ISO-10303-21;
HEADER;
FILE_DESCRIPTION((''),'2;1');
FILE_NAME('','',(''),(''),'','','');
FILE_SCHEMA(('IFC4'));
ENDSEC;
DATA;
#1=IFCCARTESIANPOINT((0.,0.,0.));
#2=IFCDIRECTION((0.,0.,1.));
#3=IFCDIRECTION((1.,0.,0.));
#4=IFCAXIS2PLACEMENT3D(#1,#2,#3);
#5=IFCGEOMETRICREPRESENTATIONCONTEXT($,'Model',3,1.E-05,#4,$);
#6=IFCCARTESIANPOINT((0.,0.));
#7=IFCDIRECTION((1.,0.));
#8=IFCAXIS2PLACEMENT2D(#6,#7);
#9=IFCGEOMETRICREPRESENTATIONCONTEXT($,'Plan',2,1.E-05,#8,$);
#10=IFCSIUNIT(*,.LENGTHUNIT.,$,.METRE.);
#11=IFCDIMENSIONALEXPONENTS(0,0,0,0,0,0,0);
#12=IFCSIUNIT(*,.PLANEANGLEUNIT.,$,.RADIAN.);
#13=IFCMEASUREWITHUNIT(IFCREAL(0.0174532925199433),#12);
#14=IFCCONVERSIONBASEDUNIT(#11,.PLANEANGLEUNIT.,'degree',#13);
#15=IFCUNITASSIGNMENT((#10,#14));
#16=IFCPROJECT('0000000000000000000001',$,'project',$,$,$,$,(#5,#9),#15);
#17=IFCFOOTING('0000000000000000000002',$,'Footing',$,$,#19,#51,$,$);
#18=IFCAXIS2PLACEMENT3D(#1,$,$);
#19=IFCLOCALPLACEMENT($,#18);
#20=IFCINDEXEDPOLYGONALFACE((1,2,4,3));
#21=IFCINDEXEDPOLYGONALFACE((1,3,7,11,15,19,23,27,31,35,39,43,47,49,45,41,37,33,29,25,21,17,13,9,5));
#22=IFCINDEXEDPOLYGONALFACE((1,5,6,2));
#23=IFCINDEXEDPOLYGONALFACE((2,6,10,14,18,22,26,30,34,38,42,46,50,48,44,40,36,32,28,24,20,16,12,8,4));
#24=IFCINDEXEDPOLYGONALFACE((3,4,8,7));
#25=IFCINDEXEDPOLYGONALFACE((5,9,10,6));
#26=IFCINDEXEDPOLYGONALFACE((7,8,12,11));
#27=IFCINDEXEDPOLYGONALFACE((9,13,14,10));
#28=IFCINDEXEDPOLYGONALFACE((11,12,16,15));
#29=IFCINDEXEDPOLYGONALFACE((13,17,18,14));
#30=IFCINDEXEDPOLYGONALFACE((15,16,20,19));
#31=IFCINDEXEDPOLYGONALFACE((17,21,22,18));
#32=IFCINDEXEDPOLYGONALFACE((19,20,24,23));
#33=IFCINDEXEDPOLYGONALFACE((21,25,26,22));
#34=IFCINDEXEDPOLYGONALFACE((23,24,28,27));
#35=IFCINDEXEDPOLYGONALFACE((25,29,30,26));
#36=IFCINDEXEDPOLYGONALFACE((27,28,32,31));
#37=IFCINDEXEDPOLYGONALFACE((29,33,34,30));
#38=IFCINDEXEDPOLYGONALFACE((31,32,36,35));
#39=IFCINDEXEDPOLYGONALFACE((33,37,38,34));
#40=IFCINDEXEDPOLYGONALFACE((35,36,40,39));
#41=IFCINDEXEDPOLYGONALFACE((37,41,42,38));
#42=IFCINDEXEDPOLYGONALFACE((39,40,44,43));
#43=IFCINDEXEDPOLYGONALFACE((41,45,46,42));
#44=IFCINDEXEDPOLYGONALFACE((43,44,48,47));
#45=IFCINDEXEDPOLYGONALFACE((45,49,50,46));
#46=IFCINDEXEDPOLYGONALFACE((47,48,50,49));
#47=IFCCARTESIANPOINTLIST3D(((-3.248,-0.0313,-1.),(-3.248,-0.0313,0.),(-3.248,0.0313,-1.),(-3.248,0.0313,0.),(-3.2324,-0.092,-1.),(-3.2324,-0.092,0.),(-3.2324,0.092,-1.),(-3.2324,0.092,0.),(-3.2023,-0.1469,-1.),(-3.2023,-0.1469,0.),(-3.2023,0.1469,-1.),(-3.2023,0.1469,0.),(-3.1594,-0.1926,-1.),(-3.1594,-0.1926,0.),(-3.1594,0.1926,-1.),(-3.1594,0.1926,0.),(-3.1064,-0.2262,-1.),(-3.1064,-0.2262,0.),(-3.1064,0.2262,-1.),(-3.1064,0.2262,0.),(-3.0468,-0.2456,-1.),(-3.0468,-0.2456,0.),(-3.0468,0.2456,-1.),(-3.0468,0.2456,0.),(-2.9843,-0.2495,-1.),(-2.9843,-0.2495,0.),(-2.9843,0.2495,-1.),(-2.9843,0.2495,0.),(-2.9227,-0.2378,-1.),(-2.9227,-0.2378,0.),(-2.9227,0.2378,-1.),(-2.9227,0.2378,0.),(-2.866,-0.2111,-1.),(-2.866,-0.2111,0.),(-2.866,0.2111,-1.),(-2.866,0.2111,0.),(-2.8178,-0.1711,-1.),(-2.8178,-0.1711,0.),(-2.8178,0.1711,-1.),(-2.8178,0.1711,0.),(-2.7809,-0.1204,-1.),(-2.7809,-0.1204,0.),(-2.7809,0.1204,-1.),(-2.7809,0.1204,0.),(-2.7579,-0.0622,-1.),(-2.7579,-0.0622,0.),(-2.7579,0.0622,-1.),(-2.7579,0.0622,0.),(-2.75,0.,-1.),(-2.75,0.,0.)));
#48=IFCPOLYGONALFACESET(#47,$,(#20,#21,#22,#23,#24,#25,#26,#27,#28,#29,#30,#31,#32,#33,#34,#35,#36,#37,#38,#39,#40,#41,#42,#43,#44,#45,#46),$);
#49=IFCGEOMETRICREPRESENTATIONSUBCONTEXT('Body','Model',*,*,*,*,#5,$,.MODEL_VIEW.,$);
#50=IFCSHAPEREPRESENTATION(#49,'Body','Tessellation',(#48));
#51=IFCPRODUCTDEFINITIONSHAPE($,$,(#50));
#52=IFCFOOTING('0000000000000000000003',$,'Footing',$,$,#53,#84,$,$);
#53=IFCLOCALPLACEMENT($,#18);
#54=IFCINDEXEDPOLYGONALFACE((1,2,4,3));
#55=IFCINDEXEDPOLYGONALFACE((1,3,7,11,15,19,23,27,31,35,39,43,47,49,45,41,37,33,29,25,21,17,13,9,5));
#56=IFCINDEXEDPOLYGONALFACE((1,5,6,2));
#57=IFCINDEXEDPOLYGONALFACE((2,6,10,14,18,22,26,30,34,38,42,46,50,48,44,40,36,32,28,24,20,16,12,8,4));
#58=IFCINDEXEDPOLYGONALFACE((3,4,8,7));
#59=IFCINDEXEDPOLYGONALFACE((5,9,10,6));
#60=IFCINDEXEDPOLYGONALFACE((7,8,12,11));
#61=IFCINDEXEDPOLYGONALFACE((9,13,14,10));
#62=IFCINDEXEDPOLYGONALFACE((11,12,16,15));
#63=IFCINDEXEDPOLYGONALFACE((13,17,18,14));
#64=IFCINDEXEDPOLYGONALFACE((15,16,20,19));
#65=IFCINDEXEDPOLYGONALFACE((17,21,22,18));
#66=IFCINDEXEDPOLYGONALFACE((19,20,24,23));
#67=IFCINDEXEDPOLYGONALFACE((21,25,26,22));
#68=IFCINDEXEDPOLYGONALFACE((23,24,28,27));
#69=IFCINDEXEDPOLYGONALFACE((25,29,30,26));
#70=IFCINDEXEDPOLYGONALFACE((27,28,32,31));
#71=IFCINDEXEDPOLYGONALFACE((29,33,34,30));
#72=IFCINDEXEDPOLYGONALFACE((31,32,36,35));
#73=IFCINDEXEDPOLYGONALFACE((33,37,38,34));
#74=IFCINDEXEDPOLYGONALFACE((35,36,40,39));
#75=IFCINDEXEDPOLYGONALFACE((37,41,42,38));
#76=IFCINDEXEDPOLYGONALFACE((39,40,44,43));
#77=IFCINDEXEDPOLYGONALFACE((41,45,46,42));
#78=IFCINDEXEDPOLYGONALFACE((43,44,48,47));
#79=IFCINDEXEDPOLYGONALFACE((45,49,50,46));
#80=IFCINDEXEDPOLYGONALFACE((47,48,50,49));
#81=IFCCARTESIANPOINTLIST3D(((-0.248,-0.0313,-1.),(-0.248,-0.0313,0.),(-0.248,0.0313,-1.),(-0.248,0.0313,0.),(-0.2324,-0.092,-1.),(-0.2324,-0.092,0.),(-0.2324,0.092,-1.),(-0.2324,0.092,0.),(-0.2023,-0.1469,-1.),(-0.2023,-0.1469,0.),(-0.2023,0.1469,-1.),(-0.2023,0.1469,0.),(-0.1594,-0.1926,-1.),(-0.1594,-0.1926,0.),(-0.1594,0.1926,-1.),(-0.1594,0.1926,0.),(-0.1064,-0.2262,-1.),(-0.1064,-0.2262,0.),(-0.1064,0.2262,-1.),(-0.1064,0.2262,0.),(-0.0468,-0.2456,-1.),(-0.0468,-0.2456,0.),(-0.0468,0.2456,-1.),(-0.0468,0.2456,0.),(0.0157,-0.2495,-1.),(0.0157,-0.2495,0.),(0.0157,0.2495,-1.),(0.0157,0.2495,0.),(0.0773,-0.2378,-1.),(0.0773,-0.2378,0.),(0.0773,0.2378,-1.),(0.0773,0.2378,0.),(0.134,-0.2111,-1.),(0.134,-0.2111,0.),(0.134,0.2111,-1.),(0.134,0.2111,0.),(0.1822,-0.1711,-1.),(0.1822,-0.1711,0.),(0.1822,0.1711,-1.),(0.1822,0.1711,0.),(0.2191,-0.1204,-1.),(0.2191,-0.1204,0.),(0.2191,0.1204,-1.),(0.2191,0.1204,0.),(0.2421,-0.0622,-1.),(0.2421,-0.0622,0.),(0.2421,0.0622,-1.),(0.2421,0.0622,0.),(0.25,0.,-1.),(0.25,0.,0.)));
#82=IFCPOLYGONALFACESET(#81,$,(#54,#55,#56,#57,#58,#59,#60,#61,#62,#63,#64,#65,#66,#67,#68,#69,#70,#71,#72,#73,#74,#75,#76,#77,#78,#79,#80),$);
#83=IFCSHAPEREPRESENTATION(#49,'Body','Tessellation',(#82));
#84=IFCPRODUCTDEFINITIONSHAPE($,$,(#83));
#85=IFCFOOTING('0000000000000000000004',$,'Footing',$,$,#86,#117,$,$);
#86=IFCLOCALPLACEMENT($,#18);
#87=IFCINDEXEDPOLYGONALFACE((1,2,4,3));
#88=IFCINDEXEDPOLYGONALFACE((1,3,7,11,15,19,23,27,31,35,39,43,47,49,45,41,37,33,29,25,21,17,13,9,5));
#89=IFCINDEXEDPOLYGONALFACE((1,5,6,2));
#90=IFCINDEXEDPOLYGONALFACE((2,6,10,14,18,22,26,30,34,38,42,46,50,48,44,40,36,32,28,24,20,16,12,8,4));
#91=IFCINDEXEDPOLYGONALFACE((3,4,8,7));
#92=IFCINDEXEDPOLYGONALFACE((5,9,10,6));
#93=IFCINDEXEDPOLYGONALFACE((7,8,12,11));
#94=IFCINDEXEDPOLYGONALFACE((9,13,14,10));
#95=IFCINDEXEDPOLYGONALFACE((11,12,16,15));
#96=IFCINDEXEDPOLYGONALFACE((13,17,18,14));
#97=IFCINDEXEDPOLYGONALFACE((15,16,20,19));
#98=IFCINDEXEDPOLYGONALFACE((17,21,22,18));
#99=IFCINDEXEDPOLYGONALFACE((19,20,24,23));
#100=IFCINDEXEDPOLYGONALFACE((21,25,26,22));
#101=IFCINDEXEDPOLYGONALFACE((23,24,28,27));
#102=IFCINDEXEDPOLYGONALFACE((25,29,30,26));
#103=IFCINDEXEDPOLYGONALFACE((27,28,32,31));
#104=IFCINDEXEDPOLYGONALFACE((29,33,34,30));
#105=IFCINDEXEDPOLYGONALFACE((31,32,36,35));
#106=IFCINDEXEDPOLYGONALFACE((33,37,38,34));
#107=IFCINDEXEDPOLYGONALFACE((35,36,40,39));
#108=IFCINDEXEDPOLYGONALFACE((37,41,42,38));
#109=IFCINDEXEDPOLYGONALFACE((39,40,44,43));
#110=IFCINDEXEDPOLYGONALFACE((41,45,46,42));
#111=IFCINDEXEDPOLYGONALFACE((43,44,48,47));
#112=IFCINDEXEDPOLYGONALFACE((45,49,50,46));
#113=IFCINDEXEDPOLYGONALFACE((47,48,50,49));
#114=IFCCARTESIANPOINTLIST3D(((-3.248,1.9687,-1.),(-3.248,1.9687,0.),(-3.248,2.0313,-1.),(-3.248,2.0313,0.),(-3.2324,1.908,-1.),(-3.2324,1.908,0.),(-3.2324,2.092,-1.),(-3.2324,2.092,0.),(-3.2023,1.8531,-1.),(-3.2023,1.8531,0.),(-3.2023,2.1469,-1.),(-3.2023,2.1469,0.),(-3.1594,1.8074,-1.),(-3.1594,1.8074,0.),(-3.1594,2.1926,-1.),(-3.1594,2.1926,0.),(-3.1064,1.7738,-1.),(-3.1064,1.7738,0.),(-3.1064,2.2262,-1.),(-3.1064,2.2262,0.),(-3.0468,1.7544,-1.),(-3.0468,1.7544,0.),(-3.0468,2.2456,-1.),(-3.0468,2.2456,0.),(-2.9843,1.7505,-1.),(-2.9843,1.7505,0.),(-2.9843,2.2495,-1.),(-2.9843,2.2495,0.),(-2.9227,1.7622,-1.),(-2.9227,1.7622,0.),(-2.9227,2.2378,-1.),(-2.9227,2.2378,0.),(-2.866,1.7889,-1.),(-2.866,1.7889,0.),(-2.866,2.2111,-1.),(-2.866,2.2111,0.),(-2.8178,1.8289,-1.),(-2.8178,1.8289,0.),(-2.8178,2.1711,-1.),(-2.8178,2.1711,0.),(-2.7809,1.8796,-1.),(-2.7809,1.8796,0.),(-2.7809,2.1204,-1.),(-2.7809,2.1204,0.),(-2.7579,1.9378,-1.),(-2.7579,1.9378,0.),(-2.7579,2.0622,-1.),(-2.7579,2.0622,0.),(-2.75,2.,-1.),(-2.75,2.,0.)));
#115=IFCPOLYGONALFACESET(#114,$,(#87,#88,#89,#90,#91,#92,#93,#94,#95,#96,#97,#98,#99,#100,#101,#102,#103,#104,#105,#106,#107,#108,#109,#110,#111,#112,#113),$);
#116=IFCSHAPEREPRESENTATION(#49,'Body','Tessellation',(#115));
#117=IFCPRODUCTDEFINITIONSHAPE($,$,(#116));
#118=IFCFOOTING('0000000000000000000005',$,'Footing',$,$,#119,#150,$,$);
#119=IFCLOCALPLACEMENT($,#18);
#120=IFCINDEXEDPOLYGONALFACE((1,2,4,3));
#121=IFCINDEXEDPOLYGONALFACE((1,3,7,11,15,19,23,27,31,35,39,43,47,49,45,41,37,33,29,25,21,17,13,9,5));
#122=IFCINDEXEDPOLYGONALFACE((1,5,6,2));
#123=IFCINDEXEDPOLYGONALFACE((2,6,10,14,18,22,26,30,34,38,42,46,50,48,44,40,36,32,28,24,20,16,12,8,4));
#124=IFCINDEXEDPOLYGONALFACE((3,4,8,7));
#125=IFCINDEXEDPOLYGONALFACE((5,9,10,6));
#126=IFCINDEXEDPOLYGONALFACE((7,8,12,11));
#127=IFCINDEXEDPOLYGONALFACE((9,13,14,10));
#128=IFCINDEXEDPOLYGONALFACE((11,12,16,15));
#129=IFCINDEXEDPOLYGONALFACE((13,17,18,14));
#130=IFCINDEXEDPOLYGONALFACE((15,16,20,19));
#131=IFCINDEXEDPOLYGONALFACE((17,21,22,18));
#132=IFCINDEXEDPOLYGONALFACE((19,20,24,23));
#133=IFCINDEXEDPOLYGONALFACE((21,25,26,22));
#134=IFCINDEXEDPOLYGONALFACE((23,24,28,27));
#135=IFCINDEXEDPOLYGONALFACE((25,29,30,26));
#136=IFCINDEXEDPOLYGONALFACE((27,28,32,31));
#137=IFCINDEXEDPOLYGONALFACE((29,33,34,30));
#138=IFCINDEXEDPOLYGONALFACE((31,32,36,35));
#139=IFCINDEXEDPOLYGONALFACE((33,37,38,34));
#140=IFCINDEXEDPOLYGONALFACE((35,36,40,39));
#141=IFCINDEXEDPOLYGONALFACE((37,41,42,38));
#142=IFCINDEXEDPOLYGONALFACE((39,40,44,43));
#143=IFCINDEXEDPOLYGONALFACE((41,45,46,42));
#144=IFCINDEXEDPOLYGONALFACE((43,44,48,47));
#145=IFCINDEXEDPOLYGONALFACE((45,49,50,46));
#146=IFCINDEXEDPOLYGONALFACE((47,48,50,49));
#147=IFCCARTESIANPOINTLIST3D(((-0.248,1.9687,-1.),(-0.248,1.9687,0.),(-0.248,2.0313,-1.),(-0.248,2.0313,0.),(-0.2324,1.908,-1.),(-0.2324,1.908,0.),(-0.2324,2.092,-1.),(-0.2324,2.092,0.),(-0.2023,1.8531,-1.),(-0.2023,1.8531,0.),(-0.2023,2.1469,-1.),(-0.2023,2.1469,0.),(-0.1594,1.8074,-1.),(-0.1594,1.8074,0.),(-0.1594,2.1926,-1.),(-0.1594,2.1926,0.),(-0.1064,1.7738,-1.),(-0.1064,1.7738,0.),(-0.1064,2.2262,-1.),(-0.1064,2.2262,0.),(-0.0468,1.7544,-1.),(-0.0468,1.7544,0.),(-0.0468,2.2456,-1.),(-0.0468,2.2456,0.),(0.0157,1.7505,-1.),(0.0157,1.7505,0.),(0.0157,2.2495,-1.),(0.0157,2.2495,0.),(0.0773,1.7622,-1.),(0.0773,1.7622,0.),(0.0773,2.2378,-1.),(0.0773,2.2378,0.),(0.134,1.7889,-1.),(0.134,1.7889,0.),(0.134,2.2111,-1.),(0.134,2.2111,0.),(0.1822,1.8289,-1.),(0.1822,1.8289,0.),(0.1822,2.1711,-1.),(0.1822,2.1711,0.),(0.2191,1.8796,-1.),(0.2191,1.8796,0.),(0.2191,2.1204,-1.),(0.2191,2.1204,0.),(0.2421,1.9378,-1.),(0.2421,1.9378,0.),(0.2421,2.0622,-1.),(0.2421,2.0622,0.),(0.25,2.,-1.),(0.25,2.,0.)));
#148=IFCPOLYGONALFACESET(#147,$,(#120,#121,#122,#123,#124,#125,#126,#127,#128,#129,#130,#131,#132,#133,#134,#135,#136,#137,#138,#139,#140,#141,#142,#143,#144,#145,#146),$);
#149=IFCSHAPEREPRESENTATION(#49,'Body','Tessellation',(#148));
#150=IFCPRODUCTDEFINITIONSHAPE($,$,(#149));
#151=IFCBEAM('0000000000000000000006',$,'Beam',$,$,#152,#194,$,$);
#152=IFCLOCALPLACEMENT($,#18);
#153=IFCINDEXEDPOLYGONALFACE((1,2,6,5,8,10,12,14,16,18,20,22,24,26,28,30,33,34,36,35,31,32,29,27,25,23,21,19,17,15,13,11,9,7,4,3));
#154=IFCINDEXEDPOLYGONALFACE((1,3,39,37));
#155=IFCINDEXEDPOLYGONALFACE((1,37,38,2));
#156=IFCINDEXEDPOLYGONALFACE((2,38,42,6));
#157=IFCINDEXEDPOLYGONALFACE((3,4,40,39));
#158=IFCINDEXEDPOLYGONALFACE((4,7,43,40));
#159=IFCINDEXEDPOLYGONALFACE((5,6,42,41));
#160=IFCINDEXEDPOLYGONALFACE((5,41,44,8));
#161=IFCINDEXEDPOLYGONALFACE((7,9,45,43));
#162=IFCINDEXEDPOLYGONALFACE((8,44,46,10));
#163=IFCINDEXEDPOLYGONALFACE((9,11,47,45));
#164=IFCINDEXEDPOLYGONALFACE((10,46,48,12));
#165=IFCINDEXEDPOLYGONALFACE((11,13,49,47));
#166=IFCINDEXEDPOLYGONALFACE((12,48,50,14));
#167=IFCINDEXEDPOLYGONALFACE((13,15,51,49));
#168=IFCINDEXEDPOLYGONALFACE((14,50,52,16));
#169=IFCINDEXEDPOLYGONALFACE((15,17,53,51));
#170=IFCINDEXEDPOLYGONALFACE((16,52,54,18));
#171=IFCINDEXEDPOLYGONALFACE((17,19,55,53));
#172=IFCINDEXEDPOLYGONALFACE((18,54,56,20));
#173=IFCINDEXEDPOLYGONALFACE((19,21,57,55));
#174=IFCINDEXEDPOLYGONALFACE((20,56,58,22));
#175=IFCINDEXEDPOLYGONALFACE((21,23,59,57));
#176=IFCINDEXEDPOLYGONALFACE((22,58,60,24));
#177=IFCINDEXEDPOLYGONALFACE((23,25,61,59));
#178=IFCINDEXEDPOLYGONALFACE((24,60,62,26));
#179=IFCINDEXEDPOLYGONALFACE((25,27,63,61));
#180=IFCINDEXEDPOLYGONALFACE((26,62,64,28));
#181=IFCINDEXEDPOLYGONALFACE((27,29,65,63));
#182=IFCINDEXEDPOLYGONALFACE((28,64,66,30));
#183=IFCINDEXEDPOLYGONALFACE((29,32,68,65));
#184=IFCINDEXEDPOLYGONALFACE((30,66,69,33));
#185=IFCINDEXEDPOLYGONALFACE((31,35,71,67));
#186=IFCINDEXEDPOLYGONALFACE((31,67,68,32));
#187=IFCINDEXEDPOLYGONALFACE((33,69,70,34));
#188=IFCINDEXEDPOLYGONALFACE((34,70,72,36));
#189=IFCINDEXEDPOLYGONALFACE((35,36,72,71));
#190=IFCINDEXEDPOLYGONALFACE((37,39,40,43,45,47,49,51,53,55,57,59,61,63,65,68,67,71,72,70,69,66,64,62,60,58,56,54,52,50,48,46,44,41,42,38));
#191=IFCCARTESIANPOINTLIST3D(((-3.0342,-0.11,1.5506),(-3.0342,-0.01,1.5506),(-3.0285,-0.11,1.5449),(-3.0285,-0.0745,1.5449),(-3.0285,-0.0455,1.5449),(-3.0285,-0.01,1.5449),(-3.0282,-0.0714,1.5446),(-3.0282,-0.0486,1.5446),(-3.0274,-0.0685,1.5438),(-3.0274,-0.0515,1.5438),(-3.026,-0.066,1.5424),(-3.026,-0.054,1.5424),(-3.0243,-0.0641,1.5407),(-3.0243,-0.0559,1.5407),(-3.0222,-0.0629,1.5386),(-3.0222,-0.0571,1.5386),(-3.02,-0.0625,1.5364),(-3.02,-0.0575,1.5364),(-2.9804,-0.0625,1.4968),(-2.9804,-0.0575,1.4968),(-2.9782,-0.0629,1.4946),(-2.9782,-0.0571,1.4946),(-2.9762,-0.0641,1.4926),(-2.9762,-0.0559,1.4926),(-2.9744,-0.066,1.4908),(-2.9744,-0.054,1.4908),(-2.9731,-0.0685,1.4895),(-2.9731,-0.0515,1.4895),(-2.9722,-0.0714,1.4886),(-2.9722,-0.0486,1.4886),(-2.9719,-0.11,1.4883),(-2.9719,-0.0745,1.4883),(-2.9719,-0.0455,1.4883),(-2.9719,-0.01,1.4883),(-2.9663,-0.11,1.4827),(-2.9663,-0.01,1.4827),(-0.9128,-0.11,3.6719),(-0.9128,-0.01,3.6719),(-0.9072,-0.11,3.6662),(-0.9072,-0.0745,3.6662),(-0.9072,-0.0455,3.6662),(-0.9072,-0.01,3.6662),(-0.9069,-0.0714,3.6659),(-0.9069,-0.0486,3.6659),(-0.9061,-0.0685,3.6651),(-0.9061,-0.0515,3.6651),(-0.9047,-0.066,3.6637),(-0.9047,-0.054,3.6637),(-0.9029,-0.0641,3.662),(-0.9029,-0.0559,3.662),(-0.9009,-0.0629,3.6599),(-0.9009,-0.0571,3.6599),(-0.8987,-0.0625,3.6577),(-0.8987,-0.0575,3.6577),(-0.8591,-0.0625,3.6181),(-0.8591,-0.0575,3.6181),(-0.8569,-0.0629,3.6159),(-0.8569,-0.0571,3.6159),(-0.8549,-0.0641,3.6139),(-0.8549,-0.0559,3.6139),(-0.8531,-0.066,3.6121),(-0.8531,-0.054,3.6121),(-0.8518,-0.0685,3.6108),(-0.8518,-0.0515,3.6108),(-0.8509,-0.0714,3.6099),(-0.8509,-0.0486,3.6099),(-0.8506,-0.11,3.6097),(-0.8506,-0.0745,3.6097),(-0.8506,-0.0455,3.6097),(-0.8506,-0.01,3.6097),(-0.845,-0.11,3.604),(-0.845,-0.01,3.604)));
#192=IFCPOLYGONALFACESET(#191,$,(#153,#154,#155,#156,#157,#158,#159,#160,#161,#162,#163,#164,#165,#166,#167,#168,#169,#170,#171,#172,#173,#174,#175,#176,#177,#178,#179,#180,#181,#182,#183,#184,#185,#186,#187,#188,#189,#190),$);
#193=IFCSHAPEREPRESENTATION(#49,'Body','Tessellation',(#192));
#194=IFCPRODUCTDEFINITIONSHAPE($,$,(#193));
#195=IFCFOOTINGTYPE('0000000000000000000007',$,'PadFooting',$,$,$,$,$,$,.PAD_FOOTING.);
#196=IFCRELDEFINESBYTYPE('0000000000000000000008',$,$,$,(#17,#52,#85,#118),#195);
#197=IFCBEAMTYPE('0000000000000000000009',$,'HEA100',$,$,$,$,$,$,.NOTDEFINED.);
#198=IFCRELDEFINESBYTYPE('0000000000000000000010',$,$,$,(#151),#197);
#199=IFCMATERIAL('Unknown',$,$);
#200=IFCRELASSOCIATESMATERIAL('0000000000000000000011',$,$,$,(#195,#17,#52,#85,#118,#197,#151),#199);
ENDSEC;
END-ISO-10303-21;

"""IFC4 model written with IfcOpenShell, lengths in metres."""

from ifc_helpers import new_model, entity, si_unit, converted_unit, frame, origin_with_axes, origin_2d_with_axis, place, context, subcontext, project, circle, i_section, extrude, material, material_profile, profile_set, profile_usage, type_object, element, save


model = new_model("IFC4")

# Units and contexts
model_context = context("Model", 3, precision=1e-05, world=origin_with_axes())
plan_context = context("Plan", 2, precision=1e-05, world=origin_2d_with_axis())
body_context = subcontext(model_context, "Body", "Model", "MODEL_VIEW")
ifc_project = project(units=[si_unit("LENGTHUNIT", "METRE"), converted_unit("PLANEANGLEUNIT", "degree", entity("IfcReal", 0.0174532925199433), si_unit("PLANEANGLEUNIT", "RADIAN"), dimensions=[0, 0, 0, 0, 0, 0, 0])], contexts=[model_context, plan_context])

# Footings
ifc_material = material(Name="Unknown")
ifc_material_profile_1 = material_profile(ifc_material, circle(Radius=0.25))
ifc_profile_set_1 = profile_set([ifc_material_profile_1], Name="Round pad")
ifc_profile_usage_1 = profile_usage(ifc_profile_set_1, cardinal=5)
footing_type = type_object("IfcFootingType", Name="PadFooting", PredefinedType="PAD_FOOTING", material=ifc_profile_set_1)
footing_1_placement = place(None, frame((-3.0, 0.0, -1.0), z_axis=(0.0, 0.0, 1.0), x_axis=(1.0, 0.0, 0.0)))
element("IfcFooting", 1, at=footing_1_placement, type_object=footing_type, material=ifc_profile_usage_1, Name="Footing", context=body_context, shape_type="SweptSolid", body=[
    extrude(circle(Radius=0.25), origin_with_axes(), (0.0, 0.0, 1.0), 1.0),
])
ifc_profile_usage_2 = profile_usage(ifc_profile_set_1, cardinal=5)
footing_2_placement = place(None, frame((0.0, 0.0, -1.0), z_axis=(0.0, 0.0, 1.0), x_axis=(1.0, 0.0, 0.0)))
element("IfcFooting", 2, at=footing_2_placement, type_object=footing_type, material=ifc_profile_usage_2, Name="Footing", context=body_context, shape_type="SweptSolid", body=[
    extrude(circle(Radius=0.25), origin_with_axes(), (0.0, 0.0, 1.0), 1.0),
])
ifc_profile_usage_3 = profile_usage(ifc_profile_set_1, cardinal=5)
footing_3_placement = place(None, frame((-3.0, 2.0, -1.0), z_axis=(0.0, 0.0, 1.0), x_axis=(1.0, 0.0, 0.0)))
element("IfcFooting", 3, at=footing_3_placement, type_object=footing_type, material=ifc_profile_usage_3, Name="Footing", context=body_context, shape_type="SweptSolid", body=[
    extrude(circle(Radius=0.25), origin_with_axes(), (0.0, 0.0, 1.0), 1.0),
])
ifc_profile_usage_4 = profile_usage(ifc_profile_set_1, cardinal=5)
footing_4_placement = place(None, frame((0.0, 2.0, -1.0), z_axis=(0.0, 0.0, 1.0), x_axis=(1.0, 0.0, 0.0)))
element("IfcFooting", 4, at=footing_4_placement, type_object=footing_type, material=ifc_profile_usage_4, Name="Footing", context=body_context, shape_type="SweptSolid", body=[
    extrude(circle(Radius=0.25), origin_with_axes(), (0.0, 0.0, 1.0), 1.0),
])

# Beam
ifc_material_profile_2 = material_profile(ifc_material, i_section(OverallWidth=0.1, OverallDepth=0.096, WebThickness=0.005, FlangeThickness=0.008, FilletRadius=0.012))
ifc_profile_set_2 = profile_set([ifc_material_profile_2])
ifc_profile_usage_5 = profile_usage(ifc_profile_set_2, cardinal=5)
beam_type = type_object("IfcBeamType", Name="HEA100", PredefinedType="NOTDEFINED", material=ifc_profile_set_2)
beam_1_placement = place(None, frame((-3.0002, -0.06, 1.5166), z_axis=(0.707107, 0.0, 0.707107), x_axis=(0.0, 1.0, 0.0)))
element("IfcBeam", 5, at=beam_1_placement, type_object=beam_type, material=ifc_profile_usage_5, Name="Beam", context=body_context, shape_type="SweptSolid", body=[
    extrude(i_section(OverallWidth=0.1, OverallDepth=0.096, WebThickness=0.005, FlangeThickness=0.008, FilletRadius=0.012), origin_with_axes(), (0.0, 0.0, 1.0), 3.0),
])

save(model, "model.ifc")
